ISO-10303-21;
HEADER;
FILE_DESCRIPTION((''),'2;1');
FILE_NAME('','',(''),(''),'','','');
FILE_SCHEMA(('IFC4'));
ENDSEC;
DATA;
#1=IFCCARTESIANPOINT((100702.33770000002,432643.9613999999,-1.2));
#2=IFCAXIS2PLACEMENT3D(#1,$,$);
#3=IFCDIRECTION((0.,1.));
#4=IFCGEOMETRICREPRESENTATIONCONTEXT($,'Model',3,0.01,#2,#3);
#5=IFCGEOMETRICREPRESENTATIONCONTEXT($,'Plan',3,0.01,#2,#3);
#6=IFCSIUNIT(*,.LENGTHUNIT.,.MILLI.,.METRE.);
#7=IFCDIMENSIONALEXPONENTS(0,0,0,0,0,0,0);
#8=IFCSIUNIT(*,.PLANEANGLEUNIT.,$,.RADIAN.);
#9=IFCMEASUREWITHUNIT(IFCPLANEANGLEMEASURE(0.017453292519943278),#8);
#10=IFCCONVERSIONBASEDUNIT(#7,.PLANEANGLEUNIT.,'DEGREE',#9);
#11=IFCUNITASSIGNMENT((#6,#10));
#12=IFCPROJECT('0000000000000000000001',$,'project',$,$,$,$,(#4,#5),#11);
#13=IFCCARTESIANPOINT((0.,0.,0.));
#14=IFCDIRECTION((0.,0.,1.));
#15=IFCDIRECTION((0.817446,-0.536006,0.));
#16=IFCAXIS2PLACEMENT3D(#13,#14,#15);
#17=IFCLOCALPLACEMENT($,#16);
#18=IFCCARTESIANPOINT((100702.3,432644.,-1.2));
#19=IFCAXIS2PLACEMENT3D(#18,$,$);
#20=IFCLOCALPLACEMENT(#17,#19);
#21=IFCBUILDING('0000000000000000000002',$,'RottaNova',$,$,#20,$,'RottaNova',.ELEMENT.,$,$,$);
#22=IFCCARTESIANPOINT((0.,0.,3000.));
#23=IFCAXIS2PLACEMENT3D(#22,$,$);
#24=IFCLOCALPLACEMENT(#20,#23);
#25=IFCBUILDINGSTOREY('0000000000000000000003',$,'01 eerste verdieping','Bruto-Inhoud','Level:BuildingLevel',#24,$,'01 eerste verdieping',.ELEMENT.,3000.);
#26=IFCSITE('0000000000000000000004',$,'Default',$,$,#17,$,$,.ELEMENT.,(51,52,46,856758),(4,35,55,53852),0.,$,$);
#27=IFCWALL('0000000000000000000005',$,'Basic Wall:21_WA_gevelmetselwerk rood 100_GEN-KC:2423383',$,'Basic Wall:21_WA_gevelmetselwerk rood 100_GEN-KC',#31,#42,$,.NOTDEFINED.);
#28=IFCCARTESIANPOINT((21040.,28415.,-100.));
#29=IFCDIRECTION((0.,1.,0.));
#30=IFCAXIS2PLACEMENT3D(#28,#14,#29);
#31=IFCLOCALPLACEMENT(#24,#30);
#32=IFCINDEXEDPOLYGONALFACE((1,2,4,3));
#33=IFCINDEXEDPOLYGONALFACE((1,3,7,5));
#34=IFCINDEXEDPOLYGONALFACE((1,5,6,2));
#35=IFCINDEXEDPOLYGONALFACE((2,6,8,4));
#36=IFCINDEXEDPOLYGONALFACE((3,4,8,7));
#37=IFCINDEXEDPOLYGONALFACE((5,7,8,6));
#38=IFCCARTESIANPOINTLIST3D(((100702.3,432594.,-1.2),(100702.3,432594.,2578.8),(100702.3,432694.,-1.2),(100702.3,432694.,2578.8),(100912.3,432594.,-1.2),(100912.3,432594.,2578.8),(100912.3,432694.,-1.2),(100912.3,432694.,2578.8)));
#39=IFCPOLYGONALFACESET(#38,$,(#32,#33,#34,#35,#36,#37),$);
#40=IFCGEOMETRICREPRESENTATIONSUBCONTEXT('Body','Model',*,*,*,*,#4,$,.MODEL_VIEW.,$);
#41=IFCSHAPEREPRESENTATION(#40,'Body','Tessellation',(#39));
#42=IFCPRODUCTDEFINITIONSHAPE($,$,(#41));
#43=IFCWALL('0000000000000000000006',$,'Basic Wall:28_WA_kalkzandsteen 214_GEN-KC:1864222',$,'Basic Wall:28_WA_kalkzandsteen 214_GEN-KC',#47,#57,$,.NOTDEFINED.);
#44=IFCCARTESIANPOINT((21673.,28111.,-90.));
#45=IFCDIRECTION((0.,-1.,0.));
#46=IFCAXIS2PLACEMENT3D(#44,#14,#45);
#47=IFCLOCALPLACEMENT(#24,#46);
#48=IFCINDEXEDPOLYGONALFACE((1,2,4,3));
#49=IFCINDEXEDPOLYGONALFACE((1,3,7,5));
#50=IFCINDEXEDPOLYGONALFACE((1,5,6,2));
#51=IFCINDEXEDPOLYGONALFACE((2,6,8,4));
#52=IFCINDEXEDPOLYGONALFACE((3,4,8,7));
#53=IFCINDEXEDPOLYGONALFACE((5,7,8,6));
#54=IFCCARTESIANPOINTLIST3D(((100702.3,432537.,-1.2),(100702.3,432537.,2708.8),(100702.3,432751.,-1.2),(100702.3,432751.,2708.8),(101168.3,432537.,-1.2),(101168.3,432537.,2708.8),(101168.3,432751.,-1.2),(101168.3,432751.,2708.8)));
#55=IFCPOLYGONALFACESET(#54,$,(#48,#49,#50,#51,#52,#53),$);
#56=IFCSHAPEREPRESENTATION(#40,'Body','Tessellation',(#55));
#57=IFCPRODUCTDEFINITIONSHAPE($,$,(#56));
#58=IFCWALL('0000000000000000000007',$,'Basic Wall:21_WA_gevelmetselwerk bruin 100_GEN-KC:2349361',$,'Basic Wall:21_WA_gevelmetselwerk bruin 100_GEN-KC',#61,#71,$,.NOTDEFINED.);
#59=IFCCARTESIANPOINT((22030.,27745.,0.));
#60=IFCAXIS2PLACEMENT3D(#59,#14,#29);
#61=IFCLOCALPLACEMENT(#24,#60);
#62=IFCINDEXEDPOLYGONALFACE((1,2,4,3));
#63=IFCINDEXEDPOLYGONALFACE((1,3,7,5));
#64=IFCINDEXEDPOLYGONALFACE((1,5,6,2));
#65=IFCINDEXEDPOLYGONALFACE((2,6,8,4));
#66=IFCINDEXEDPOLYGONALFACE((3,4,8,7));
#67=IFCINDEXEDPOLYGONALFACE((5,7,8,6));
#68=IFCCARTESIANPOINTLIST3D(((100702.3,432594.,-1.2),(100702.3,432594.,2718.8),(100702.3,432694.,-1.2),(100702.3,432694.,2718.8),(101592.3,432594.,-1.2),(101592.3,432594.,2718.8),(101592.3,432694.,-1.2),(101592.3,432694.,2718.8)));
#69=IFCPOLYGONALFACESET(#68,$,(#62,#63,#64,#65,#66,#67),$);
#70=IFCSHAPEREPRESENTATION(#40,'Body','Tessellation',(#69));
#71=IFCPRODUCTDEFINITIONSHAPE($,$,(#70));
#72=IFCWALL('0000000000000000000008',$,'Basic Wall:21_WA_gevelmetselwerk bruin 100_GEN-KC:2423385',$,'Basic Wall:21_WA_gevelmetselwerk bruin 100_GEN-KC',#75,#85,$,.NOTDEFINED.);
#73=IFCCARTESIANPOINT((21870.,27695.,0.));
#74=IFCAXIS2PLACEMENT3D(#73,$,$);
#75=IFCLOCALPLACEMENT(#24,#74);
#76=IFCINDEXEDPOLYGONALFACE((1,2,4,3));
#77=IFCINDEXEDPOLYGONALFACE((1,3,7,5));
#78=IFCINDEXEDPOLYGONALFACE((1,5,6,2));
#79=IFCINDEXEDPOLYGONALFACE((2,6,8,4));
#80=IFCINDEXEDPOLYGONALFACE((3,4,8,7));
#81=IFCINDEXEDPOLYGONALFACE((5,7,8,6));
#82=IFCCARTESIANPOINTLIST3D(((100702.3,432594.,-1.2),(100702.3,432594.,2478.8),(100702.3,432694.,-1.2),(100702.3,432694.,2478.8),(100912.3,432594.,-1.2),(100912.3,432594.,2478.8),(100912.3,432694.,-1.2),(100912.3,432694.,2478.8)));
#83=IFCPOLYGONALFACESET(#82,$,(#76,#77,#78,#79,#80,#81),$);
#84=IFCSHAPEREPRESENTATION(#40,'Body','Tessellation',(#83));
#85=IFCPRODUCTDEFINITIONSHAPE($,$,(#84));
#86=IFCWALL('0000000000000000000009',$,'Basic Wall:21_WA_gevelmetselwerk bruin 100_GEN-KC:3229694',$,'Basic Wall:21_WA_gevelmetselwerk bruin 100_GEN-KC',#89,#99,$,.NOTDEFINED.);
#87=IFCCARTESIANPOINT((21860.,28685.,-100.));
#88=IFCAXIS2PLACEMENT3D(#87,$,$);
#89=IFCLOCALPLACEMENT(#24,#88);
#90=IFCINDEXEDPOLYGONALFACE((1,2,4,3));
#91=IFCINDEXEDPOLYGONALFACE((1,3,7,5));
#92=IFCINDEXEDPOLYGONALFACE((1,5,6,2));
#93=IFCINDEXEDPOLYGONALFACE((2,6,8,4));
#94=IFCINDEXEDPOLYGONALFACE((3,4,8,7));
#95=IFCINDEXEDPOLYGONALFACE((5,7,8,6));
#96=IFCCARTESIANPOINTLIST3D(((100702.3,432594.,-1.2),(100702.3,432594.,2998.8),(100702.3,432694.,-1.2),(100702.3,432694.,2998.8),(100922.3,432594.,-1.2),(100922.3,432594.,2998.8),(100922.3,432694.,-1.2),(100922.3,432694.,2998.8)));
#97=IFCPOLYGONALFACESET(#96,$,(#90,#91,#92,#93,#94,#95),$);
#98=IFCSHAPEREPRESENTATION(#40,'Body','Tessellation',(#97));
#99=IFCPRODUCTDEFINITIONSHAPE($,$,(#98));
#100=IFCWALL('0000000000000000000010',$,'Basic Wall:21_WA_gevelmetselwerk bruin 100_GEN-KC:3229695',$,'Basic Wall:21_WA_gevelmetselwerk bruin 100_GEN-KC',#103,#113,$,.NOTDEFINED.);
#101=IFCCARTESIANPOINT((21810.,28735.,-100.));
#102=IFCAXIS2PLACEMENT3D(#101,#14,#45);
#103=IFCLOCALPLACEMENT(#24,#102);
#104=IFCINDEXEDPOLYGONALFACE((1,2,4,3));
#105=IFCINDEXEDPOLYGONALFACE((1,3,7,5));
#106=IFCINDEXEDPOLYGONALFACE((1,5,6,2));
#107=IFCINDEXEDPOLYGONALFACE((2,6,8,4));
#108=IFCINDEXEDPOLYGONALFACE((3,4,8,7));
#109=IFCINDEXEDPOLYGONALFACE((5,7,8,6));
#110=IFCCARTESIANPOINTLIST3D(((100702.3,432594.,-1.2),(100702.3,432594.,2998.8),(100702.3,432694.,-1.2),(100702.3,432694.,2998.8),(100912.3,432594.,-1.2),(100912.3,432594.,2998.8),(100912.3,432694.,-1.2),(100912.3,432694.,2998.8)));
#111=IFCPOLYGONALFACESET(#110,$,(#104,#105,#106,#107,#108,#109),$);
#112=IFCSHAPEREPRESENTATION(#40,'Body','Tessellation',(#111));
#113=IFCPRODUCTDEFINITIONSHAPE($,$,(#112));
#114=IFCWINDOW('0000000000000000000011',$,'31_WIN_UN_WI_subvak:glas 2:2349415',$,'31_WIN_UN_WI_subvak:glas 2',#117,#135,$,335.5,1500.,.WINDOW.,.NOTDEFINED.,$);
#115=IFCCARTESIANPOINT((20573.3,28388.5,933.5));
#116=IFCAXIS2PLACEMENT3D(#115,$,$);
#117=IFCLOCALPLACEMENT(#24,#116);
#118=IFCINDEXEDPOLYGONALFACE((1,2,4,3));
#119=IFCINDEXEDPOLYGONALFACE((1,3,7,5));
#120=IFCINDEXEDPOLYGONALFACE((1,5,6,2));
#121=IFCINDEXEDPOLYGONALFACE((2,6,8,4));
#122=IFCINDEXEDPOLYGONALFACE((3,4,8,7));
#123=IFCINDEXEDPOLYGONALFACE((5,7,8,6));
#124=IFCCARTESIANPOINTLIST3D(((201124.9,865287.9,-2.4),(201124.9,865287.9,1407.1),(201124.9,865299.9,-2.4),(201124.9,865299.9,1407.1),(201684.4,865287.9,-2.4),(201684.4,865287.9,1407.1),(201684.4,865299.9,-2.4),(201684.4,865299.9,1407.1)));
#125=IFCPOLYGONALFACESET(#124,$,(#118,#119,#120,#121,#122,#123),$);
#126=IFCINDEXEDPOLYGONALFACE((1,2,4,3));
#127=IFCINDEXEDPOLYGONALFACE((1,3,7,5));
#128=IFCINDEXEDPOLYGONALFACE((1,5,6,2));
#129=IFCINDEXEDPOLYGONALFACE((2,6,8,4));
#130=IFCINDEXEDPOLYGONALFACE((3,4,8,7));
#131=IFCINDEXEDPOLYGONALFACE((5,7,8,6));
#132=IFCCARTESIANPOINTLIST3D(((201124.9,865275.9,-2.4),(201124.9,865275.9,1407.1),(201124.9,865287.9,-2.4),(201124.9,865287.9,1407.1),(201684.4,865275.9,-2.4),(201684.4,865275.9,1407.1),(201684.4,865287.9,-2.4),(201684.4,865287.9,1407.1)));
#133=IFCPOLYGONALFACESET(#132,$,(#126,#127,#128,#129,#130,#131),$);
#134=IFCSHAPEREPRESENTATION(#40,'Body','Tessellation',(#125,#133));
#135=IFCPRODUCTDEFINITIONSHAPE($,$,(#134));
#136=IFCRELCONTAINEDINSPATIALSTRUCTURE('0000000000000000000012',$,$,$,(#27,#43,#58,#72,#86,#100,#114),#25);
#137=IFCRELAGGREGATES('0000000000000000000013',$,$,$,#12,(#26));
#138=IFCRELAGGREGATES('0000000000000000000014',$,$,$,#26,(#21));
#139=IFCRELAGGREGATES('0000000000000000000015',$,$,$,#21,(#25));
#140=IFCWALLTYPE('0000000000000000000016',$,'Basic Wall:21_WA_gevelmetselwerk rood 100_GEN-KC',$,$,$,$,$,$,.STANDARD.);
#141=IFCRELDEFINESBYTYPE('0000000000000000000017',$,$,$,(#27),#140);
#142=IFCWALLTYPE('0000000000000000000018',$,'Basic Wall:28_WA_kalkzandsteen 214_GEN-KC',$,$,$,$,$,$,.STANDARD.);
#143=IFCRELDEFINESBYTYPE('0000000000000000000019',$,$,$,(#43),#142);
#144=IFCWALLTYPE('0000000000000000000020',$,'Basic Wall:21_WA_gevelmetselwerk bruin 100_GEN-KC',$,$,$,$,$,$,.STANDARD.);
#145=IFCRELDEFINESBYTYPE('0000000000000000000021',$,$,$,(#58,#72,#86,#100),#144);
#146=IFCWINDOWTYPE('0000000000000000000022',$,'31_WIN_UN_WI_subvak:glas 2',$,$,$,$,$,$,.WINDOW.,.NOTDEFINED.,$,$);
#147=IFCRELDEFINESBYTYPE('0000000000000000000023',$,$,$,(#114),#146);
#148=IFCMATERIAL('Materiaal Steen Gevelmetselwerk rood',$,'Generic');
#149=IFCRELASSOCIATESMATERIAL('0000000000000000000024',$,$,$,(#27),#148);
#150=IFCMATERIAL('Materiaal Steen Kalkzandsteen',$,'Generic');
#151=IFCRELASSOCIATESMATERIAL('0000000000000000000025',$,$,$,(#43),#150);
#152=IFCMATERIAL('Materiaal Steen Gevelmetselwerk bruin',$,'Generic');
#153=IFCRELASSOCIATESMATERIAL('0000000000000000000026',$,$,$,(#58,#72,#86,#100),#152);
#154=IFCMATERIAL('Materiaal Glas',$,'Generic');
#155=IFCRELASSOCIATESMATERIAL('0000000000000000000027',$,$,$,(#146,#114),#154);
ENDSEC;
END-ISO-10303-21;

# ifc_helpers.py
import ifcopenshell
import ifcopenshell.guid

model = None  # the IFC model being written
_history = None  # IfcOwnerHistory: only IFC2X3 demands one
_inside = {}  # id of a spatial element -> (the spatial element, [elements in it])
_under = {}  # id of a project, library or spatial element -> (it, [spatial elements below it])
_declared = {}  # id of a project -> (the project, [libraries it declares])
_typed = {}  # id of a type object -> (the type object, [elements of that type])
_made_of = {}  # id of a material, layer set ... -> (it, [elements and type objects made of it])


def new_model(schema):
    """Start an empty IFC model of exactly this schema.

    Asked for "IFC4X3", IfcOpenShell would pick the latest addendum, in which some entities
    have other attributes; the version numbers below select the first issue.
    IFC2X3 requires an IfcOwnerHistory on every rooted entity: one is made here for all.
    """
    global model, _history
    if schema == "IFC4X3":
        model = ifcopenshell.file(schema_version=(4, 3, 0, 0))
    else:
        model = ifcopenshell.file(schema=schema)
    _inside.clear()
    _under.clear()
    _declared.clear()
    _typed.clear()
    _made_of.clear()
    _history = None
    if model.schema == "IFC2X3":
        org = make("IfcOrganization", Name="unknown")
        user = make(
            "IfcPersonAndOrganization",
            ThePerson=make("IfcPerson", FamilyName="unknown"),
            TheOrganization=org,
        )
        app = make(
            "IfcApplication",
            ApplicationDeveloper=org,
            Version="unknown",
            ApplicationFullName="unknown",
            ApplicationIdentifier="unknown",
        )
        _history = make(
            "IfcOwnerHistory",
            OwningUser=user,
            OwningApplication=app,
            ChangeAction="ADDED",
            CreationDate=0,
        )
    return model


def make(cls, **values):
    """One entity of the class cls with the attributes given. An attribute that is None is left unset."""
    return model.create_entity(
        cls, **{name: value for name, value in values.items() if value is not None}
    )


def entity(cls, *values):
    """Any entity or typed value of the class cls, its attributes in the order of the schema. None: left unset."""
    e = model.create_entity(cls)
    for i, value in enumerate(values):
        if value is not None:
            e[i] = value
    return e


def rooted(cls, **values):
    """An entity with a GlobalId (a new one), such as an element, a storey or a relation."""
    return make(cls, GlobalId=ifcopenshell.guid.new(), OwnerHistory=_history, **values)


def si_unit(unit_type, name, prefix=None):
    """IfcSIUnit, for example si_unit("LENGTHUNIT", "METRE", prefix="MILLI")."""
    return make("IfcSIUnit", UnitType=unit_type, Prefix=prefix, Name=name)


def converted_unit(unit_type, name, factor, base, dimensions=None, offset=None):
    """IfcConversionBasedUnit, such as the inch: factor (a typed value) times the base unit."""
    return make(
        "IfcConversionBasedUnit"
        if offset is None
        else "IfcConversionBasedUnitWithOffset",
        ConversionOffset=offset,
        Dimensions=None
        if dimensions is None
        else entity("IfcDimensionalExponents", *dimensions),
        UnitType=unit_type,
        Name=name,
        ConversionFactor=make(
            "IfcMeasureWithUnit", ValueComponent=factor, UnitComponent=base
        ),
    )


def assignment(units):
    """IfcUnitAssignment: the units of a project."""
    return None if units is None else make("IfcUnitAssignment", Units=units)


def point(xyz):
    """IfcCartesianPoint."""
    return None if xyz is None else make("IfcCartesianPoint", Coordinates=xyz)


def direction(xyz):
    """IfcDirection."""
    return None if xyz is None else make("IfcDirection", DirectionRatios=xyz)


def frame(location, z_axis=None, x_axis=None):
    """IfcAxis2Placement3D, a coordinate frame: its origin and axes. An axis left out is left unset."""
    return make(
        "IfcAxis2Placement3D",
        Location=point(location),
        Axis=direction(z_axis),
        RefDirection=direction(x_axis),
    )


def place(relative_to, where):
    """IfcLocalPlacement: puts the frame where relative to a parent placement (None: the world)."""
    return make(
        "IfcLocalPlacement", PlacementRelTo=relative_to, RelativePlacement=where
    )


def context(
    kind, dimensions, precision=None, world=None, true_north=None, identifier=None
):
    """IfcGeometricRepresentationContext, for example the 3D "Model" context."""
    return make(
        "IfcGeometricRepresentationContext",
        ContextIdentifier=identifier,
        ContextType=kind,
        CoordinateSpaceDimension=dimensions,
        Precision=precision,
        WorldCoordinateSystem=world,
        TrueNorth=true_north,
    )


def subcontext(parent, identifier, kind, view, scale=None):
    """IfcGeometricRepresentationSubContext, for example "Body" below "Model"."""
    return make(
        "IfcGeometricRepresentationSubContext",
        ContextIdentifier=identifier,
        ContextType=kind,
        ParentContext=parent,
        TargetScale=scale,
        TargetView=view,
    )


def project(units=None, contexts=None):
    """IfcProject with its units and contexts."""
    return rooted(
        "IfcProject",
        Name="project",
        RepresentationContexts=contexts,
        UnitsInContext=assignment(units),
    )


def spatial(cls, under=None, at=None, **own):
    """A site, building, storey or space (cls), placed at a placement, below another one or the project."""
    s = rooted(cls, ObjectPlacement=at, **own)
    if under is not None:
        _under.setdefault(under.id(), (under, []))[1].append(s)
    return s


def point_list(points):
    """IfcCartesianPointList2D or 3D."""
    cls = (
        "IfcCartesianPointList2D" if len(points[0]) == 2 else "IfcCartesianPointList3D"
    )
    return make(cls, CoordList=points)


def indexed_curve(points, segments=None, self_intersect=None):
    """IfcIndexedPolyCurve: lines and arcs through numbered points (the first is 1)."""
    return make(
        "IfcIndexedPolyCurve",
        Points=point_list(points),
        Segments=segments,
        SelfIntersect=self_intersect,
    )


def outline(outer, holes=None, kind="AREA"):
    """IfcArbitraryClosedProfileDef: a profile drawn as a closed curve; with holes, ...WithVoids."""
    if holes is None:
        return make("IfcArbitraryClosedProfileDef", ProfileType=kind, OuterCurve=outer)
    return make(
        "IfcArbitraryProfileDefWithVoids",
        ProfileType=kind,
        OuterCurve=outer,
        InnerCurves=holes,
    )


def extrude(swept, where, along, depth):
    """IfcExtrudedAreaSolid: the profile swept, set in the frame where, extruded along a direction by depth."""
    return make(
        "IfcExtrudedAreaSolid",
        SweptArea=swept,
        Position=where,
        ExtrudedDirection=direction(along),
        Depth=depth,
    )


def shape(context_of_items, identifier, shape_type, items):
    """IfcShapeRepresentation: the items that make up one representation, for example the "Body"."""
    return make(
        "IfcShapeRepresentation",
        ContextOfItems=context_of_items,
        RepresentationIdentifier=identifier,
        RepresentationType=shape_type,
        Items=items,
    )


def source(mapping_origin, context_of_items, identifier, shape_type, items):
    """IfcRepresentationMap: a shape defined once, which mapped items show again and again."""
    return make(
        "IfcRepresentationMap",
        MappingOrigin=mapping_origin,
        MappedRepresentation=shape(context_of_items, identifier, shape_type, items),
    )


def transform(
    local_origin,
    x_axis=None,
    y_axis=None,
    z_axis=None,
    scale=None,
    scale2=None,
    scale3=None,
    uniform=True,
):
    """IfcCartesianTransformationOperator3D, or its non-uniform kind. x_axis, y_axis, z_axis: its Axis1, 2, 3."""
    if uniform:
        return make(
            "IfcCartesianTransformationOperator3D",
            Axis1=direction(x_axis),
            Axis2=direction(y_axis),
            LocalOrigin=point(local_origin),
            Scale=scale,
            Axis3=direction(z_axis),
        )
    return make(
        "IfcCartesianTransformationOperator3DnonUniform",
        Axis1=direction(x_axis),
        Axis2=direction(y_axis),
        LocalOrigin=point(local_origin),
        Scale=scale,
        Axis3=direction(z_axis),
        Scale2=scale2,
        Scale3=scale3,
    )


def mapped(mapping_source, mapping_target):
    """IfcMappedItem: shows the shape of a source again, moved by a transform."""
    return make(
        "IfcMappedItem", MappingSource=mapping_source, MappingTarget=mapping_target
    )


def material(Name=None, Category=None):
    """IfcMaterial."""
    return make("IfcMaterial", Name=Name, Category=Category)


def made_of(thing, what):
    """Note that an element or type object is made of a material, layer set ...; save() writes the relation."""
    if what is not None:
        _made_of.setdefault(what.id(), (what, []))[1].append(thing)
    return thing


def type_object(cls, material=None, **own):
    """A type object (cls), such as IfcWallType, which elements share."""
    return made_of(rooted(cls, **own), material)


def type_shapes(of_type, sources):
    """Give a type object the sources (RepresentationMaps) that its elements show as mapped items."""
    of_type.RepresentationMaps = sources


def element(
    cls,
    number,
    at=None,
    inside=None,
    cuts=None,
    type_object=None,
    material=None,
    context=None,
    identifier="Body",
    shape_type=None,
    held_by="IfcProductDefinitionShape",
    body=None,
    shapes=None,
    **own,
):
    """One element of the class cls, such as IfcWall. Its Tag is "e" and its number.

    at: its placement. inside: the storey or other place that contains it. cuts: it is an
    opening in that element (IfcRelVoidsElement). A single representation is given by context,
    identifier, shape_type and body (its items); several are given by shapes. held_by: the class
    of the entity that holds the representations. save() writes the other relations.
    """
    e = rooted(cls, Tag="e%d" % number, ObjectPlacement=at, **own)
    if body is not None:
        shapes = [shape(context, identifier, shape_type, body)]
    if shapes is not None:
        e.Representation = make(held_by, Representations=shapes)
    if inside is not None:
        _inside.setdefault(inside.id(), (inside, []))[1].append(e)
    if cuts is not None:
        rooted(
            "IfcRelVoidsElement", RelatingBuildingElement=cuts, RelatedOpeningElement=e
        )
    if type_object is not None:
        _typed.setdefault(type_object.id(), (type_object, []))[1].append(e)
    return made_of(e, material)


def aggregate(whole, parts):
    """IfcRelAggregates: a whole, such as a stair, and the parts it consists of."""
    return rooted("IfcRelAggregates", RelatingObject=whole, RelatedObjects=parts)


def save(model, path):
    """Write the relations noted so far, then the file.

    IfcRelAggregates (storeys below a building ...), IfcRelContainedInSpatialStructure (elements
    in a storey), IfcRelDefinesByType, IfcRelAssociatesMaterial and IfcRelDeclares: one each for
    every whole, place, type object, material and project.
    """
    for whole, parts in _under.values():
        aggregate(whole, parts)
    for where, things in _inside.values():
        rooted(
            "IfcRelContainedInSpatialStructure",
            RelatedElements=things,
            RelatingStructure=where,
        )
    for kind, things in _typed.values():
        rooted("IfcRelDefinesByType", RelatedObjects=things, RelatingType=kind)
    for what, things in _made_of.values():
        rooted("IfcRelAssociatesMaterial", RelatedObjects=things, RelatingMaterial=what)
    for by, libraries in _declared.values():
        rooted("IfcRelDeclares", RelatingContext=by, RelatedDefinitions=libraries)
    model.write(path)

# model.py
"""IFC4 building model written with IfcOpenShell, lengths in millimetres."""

from ifc_helpers import new_model, entity, si_unit, converted_unit, direction, frame, place, context, subcontext, project, spatial, indexed_curve, outline, extrude, source, transform, mapped, material, type_object, type_shapes, element, save


model = new_model("IFC4")

# Units and contexts
model_context = context("Model", 3, precision=0.01, world=frame((100702.33770000002, 432643.9613999999, -1.2)), true_north=direction((0.0, 1.0)))
plan_context = context("Plan", 3, precision=0.01, world=frame((100702.33770000002, 432643.9613999999, -1.2)), true_north=direction((0.0, 1.0)))
body_context = subcontext(model_context, "Body", "Model", "MODEL_VIEW")
ifc_project = project(units=[si_unit("LENGTHUNIT", "METRE", prefix="MILLI"), converted_unit("PLANEANGLEUNIT", "DEGREE", entity("IfcPlaneAngleMeasure", 0.017453292519943278), si_unit("PLANEANGLEUNIT", "RADIAN"), dimensions=[0, 0, 0, 0, 0, 0, 0])], contexts=[model_context, plan_context])

# Site, building, storey
site_placement = place(None, frame((0.0, 0.0, 0.0), z_axis=(0.0, 0.0, 1.0), x_axis=(0.817446, -0.536006, 0.0)))
site = spatial("IfcSite", under=ifc_project, at=site_placement, Name="Default", CompositionType="ELEMENT", RefLatitude=(51, 52, 46, 856758), RefLongitude=(4, 35, 55, 53852), RefElevation=0.0)
building_placement = place(site_placement, frame((100702.3, 432644.0, -1.2)))
building = spatial("IfcBuilding", under=site, at=building_placement, Name="RottaNova", LongName="RottaNova", CompositionType="ELEMENT")
storey_placement = place(building_placement, frame((0.0, 0.0, 3000.0)))
storey = spatial("IfcBuildingStorey", under=building, at=storey_placement, Name="01 eerste verdieping", Description="Bruto-Inhoud", ObjectType="Level:BuildingLevel", LongName="01 eerste verdieping", CompositionType="ELEMENT", Elevation=3000.0)

# Shared definitions
ifc_material_1 = material(Name="Materiaal Glas", Category="Generic")

# Walls
ifc_material_2 = material(Name="Materiaal Steen Gevelmetselwerk rood", Category="Generic")
wall_type_1 = type_object("IfcWallType", Name="Basic Wall:21_WA_gevelmetselwerk rood 100_GEN-KC", PredefinedType="STANDARD")
wall_1_placement = place(storey_placement, frame((21040.0, 28415.0, -100.0), z_axis=(0.0, 0.0, 1.0), x_axis=(0.0, 1.0, 0.0)))
element("IfcWall", 1, at=wall_1_placement, inside=storey, type_object=wall_type_1, material=ifc_material_2, Name="Basic Wall:21_WA_gevelmetselwerk rood 100_GEN-KC:2423383", ObjectType="Basic Wall:21_WA_gevelmetselwerk rood 100_GEN-KC", PredefinedType="NOTDEFINED", context=body_context, shape_type="SweptSolid", body=[
    extrude(outline(indexed_curve([(210.0, 50.0), (0.0, 50.0), (0.0, -50.0), (210.0, -50.0), (210.0, 50.0)], self_intersect=False)), frame((100702.3, 432644.0, -1.2)), (0.0, 0.0, 1.0), 2580.0),
])
ifc_material_3 = material(Name="Materiaal Steen Kalkzandsteen", Category="Generic")
wall_type_2 = type_object("IfcWallType", Name="Basic Wall:28_WA_kalkzandsteen 214_GEN-KC", PredefinedType="STANDARD")
wall_2_placement = place(storey_placement, frame((21673.0, 28111.0, -90.0), z_axis=(0.0, 0.0, 1.0), x_axis=(0.0, -1.0, 0.0)))
element("IfcWall", 2, at=wall_2_placement, inside=storey, type_object=wall_type_2, material=ifc_material_3, Name="Basic Wall:28_WA_kalkzandsteen 214_GEN-KC:1864222", ObjectType="Basic Wall:28_WA_kalkzandsteen 214_GEN-KC", PredefinedType="NOTDEFINED", context=body_context, shape_type="SweptSolid", body=[
    extrude(outline(indexed_curve([(466.0, 107.0), (0.0, 107.0), (0.0, -107.0), (466.0, -107.0), (466.0, 107.0)], self_intersect=False)), frame((100702.3, 432644.0, -1.2)), (0.0, 0.0, 1.0), 2710.0),
])
ifc_material_4 = material(Name="Materiaal Steen Gevelmetselwerk bruin", Category="Generic")
wall_type_3 = type_object("IfcWallType", Name="Basic Wall:21_WA_gevelmetselwerk bruin 100_GEN-KC", PredefinedType="STANDARD")
wall_3_placement = place(storey_placement, frame((22030.0, 27745.0, 0.0), z_axis=(0.0, 0.0, 1.0), x_axis=(0.0, 1.0, 0.0)))
element("IfcWall", 3, at=wall_3_placement, inside=storey, type_object=wall_type_3, material=ifc_material_4, Name="Basic Wall:21_WA_gevelmetselwerk bruin 100_GEN-KC:2349361", ObjectType="Basic Wall:21_WA_gevelmetselwerk bruin 100_GEN-KC", PredefinedType="NOTDEFINED", context=body_context, shape_type="SweptSolid", body=[
    extrude(outline(indexed_curve([(890.0, 50.0), (0.0, 50.0), (0.0, -50.0), (890.0, -50.0), (890.0, 50.0)], self_intersect=False)), frame((100702.3, 432644.0, -1.2)), (0.0, 0.0, 1.0), 2720.0),
])
wall_4_placement = place(storey_placement, frame((21870.0, 27695.0, 0.0)))
element("IfcWall", 4, at=wall_4_placement, inside=storey, type_object=wall_type_3, material=ifc_material_4, Name="Basic Wall:21_WA_gevelmetselwerk bruin 100_GEN-KC:2423385", ObjectType="Basic Wall:21_WA_gevelmetselwerk bruin 100_GEN-KC", PredefinedType="NOTDEFINED", context=body_context, shape_type="SweptSolid", body=[
    extrude(outline(indexed_curve([(210.0, 50.0), (0.0, 50.0), (0.0, -50.0), (210.0, -50.0), (210.0, 50.0)], self_intersect=False)), frame((100702.3, 432644.0, -1.2)), (0.0, 0.0, 1.0), 2480.0),
])
wall_5_placement = place(storey_placement, frame((21860.0, 28685.0, -100.0)))
element("IfcWall", 5, at=wall_5_placement, inside=storey, type_object=wall_type_3, material=ifc_material_4, Name="Basic Wall:21_WA_gevelmetselwerk bruin 100_GEN-KC:3229694", ObjectType="Basic Wall:21_WA_gevelmetselwerk bruin 100_GEN-KC", PredefinedType="NOTDEFINED", context=body_context, shape_type="SweptSolid", body=[
    extrude(outline(indexed_curve([(220.0, 50.0), (0.0, 50.0), (0.0, -50.0), (220.0, -50.0), (220.0, 50.0)], self_intersect=False)), frame((100702.3, 432644.0, -1.2)), (0.0, 0.0, 1.0), 3000.0),
])
wall_6_placement = place(storey_placement, frame((21810.0, 28735.0, -100.0), z_axis=(0.0, 0.0, 1.0), x_axis=(0.0, -1.0, 0.0)))
element("IfcWall", 6, at=wall_6_placement, inside=storey, type_object=wall_type_3, material=ifc_material_4, Name="Basic Wall:21_WA_gevelmetselwerk bruin 100_GEN-KC:3229695", ObjectType="Basic Wall:21_WA_gevelmetselwerk bruin 100_GEN-KC", PredefinedType="NOTDEFINED", context=body_context, shape_type="SweptSolid", body=[
    extrude(outline(indexed_curve([(210.0, 50.0), (0.0, 50.0), (0.0, -50.0), (210.0, -50.0), (210.0, 50.0)], self_intersect=False)), frame((100702.3, 432644.0, -1.2)), (0.0, 0.0, 1.0), 3000.0),
])

# Window
window_type = type_object("IfcWindowType", Name="31_WIN_UN_WI_subvak:glas 2", PartitioningType="NOTDEFINED", PredefinedType="WINDOW", material=ifc_material_1)
shared_shape_1 = source(frame((100702.3, 432644.0, -1.2)), body_context, "Body", "SweptSolid", [
    extrude(outline(indexed_curve([(-6.0, -279.8), (6.0, -279.8), (6.0, 279.8), (-6.0, 279.8), (-6.0, -279.8)], self_intersect=False)), frame((0.0, 6.0, 0.0), z_axis=(0.0, 0.0, 1.0), x_axis=(0.0, -1.0, 0.0)), (0.0, 0.0, 1.0), 1409.5),
    extrude(outline(indexed_curve([(-6.0, -279.8), (6.0, -279.8), (6.0, 279.8), (-6.0, 279.8), (-6.0, -279.8)], self_intersect=False)), frame((0.0, -6.0, 0.0), z_axis=(0.0, 0.0, 1.0), x_axis=(0.0, -1.0, 0.0)), (0.0, 0.0, 1.0), 1409.5),
])
type_shapes(window_type, [shared_shape_1])
window_1_placement = place(storey_placement, frame((20573.3, 28388.5, 933.5)))
element("IfcWindow", 7, at=window_1_placement, inside=storey, type_object=window_type, material=ifc_material_1, Name="31_WIN_UN_WI_subvak:glas 2:2349415", ObjectType="31_WIN_UN_WI_subvak:glas 2", OverallHeight=335.5, OverallWidth=1500.0, PartitioningType="NOTDEFINED", PredefinedType="WINDOW", context=body_context, shape_type="MappedRepresentation", body=[
    mapped(shared_shape_1, transform((100702.3, 432644.0, -1.2), scale=1.0)),
])

save(model, "model.ifc")
